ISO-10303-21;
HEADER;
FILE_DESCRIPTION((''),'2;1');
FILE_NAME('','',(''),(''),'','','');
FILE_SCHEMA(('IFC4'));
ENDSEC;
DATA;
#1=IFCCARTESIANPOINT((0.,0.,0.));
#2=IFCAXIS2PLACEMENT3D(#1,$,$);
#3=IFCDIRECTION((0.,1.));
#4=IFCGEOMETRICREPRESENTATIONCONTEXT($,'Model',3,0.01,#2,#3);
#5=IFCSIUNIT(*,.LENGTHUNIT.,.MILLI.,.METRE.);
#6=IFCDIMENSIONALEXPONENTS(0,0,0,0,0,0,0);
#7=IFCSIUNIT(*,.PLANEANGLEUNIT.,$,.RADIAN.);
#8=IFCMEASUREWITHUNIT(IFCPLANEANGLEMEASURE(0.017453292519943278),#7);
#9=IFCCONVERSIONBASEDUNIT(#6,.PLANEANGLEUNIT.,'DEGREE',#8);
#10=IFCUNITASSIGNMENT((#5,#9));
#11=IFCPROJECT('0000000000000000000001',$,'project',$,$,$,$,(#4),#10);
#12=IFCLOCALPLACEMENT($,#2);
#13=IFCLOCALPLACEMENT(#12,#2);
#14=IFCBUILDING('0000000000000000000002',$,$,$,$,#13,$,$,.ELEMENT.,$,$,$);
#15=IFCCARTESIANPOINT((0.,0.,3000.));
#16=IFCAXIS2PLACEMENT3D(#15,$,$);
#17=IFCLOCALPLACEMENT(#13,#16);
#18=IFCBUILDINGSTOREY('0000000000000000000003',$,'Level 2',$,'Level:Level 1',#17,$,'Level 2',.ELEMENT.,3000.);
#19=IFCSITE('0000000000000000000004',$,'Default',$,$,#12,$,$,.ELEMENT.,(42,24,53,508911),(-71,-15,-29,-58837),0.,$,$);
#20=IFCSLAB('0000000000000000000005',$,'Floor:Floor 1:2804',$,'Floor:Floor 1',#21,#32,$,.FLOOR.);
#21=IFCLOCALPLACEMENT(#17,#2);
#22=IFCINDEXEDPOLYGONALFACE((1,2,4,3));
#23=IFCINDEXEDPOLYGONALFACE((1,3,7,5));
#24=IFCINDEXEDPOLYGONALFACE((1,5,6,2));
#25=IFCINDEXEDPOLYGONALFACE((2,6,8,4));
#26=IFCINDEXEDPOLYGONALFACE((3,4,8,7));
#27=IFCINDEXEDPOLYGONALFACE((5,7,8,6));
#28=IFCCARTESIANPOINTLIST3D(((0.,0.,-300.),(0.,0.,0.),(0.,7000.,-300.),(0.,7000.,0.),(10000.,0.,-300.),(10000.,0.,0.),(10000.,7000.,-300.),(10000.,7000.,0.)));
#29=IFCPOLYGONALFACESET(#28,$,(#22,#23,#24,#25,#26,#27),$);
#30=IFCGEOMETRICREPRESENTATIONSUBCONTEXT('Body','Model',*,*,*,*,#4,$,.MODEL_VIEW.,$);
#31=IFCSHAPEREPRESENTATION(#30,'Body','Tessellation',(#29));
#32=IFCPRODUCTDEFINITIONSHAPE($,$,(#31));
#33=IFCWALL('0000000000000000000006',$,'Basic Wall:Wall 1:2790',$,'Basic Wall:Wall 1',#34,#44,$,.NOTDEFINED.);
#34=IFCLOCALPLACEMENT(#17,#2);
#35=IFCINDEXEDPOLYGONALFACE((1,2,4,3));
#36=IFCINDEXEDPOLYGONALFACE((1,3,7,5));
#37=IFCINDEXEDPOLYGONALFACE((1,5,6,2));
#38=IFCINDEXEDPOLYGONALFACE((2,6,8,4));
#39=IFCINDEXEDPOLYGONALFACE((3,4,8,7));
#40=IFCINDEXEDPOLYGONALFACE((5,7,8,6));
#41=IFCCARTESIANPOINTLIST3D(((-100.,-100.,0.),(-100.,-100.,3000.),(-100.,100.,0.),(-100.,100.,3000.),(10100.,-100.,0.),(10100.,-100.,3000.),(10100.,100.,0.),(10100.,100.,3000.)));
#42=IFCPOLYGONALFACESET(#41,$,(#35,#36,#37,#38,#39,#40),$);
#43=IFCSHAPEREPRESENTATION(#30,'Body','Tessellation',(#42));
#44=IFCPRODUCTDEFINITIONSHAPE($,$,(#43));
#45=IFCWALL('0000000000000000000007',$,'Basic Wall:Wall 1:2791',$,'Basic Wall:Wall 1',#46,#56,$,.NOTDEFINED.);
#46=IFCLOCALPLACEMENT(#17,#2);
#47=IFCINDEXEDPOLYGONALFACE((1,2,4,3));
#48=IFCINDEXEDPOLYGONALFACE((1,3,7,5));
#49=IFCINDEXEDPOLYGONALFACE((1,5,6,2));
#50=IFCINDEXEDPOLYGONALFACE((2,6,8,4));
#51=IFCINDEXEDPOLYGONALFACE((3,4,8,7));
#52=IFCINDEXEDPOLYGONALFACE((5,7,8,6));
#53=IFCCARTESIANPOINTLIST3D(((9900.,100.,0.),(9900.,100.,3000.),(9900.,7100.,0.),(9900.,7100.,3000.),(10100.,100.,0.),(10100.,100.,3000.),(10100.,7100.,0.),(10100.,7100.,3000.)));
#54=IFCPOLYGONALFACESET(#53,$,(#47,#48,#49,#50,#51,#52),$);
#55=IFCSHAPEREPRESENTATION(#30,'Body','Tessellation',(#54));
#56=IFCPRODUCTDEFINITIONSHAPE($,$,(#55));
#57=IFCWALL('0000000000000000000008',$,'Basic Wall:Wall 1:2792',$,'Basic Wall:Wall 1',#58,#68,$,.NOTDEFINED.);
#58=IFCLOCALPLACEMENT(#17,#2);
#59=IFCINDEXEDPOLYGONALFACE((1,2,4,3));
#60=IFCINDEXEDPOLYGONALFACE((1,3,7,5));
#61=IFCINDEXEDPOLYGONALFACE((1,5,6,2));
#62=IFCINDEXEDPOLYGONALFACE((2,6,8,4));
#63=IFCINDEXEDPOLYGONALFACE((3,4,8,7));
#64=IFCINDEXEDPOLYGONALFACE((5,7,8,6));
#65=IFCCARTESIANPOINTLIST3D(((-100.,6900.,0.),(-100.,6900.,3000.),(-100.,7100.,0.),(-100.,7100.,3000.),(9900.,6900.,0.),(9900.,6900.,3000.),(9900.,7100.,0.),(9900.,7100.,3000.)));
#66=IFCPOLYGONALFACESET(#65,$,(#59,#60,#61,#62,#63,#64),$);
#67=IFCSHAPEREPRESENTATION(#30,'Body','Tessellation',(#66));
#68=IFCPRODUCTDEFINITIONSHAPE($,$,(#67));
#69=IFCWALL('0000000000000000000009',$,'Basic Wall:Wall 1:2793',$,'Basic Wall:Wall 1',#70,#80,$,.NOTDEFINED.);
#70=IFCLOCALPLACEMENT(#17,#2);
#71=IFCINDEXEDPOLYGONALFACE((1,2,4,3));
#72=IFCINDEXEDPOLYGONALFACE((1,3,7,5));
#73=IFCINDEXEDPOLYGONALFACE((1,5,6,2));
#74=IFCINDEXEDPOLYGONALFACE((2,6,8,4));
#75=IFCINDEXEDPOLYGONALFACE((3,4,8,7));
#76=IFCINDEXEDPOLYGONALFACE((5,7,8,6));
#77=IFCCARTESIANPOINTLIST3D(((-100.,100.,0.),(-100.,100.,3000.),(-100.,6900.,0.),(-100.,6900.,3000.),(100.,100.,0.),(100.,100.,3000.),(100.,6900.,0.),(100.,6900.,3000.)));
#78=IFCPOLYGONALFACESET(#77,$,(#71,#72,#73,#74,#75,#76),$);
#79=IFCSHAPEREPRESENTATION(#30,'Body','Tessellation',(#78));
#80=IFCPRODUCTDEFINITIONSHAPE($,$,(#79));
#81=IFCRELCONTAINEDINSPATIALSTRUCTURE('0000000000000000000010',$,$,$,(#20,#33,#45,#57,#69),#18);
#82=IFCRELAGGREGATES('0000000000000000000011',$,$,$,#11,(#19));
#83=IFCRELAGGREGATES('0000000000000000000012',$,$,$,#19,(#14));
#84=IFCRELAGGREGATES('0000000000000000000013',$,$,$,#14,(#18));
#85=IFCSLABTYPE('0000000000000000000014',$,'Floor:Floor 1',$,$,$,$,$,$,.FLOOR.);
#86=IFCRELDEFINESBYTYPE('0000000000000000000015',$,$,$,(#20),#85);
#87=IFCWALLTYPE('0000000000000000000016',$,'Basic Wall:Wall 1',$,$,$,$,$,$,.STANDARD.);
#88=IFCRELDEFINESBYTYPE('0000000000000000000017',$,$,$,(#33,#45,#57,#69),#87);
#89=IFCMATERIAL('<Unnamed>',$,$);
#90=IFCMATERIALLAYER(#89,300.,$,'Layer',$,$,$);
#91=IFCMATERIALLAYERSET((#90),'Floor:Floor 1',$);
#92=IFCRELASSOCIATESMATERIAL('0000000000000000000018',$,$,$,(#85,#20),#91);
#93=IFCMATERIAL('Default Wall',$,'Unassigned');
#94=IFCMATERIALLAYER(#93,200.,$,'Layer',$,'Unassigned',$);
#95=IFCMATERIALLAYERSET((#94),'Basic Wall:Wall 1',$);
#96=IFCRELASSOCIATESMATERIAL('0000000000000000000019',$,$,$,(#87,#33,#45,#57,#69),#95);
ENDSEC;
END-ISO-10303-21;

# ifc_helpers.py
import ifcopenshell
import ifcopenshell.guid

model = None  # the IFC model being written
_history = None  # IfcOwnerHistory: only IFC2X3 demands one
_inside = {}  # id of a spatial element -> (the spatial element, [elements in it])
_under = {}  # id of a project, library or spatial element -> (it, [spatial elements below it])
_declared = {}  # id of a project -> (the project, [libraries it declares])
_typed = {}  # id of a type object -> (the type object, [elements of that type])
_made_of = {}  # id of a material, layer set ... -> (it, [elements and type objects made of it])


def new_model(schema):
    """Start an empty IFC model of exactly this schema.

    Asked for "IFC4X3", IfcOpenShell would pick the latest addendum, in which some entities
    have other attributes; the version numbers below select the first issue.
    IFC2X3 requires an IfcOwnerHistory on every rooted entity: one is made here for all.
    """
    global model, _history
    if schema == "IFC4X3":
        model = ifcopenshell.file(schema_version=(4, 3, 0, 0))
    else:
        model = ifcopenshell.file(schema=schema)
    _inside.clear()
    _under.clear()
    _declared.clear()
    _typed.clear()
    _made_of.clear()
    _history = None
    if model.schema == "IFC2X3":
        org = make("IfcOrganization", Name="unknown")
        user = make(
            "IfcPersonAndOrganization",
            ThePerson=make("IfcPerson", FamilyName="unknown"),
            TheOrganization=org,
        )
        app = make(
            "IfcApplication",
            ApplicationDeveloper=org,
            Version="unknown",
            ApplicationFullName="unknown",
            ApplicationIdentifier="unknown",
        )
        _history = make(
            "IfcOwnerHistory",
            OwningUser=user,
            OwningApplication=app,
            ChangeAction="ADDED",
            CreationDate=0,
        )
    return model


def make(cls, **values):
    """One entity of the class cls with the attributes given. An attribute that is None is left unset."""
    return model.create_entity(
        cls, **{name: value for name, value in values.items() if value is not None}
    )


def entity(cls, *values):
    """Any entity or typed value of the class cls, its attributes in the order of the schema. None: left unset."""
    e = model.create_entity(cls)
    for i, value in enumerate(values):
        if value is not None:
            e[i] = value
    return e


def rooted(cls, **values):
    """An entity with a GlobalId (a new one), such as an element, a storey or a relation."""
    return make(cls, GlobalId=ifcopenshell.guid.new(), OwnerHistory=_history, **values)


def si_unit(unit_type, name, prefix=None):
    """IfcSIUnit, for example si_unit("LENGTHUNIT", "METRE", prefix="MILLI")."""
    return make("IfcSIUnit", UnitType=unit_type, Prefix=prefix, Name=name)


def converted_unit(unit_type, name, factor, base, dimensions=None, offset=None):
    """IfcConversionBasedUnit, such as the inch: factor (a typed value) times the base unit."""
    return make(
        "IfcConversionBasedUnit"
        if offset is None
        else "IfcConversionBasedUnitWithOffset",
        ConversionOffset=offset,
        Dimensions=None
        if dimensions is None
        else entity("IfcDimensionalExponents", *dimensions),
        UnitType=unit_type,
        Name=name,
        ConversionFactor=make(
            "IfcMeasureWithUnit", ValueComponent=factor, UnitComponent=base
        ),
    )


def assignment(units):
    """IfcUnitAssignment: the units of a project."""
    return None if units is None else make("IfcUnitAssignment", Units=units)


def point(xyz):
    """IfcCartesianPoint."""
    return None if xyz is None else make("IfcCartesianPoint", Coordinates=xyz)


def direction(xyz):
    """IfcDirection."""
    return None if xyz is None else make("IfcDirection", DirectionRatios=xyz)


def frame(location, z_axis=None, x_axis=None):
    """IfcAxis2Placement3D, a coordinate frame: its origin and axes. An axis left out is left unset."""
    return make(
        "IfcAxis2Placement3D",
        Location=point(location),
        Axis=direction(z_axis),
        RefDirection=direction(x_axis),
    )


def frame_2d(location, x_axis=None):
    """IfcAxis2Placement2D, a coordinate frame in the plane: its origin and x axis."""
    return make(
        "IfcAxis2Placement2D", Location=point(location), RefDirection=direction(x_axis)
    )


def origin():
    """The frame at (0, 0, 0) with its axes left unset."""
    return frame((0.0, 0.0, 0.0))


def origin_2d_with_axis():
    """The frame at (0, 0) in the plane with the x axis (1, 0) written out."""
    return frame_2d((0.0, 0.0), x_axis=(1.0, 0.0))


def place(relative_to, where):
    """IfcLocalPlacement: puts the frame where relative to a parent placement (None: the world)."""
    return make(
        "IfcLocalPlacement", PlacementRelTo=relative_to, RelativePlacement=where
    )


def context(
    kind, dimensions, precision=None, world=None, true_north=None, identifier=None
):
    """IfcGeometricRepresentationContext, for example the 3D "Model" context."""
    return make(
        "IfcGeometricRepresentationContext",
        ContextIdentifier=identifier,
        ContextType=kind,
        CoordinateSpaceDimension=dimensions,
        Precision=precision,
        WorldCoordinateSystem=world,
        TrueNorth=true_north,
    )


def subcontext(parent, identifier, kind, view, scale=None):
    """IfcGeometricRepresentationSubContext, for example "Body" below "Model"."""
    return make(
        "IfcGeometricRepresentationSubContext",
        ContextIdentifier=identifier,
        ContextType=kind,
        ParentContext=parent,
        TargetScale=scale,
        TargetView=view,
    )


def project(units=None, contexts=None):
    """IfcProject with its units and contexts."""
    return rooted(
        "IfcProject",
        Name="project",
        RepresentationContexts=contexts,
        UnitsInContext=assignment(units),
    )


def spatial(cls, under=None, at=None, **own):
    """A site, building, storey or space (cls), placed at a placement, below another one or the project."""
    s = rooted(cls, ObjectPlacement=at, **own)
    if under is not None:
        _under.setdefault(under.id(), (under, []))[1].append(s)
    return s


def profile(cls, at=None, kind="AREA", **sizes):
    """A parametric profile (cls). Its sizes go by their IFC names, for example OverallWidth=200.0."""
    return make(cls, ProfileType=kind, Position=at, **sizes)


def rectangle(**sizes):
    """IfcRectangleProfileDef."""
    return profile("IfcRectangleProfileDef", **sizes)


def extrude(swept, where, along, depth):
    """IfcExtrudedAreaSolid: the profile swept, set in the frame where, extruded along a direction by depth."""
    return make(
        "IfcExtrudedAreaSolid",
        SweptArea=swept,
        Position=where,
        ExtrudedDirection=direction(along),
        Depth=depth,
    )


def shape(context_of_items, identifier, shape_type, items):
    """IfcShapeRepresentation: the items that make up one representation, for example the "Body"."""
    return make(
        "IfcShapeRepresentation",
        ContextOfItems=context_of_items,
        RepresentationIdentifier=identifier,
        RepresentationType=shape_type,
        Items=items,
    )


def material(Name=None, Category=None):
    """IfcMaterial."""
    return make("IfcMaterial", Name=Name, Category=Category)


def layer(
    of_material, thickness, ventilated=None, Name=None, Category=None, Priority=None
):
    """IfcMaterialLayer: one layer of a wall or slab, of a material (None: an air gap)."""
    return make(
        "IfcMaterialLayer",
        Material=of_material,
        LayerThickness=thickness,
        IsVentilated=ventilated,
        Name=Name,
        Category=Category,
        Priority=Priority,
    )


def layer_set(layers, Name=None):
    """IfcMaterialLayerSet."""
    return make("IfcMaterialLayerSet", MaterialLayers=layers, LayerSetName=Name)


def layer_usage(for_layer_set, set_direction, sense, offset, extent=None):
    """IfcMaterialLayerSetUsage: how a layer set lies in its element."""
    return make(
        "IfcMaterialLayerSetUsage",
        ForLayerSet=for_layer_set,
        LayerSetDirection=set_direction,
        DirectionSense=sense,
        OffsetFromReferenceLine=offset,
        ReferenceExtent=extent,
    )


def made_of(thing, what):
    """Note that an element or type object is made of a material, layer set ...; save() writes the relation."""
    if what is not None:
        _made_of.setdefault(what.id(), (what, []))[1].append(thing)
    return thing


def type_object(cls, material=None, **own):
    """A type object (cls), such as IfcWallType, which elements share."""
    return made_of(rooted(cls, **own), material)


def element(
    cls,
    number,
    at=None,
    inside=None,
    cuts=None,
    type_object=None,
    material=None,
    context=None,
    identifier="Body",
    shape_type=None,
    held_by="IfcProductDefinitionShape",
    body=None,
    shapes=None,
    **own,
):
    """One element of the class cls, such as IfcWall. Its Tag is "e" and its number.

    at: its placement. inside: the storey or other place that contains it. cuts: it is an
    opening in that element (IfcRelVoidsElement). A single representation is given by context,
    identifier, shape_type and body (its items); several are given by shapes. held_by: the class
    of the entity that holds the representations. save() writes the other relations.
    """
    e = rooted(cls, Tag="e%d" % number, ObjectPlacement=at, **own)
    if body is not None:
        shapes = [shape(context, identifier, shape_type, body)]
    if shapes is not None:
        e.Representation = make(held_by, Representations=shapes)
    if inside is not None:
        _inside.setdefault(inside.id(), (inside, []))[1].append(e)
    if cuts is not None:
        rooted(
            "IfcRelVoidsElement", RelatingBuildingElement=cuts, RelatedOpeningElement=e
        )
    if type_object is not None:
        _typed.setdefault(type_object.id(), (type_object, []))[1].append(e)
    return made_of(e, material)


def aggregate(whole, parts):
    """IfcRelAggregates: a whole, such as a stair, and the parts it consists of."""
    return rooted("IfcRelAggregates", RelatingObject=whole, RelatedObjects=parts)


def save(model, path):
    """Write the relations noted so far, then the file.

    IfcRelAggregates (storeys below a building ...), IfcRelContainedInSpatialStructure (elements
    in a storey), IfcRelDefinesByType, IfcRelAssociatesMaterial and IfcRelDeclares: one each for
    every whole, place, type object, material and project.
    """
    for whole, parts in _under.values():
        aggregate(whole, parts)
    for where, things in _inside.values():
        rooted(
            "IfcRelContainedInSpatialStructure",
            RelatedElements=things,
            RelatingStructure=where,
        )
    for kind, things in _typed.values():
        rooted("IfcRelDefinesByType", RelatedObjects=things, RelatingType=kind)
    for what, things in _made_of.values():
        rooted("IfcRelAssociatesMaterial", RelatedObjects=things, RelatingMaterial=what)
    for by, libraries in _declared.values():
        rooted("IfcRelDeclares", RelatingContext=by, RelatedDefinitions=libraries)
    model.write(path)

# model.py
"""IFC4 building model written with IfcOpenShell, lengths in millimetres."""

from ifc_helpers import new_model, entity, si_unit, converted_unit, direction, frame, frame_2d, origin, origin_2d_with_axis, place, context, subcontext, project, spatial, rectangle, extrude, material, layer, layer_set, layer_usage, type_object, element, save


model = new_model("IFC4")

# Units and contexts
model_context = context("Model", 3, precision=0.01, world=origin(), true_north=direction((0.0, 1.0)))
body_context = subcontext(model_context, "Body", "Model", "MODEL_VIEW")
ifc_project = project(units=[si_unit("LENGTHUNIT", "METRE", prefix="MILLI"), converted_unit("PLANEANGLEUNIT", "DEGREE", entity("IfcPlaneAngleMeasure", 0.017453292519943278), si_unit("PLANEANGLEUNIT", "RADIAN"), dimensions=[0, 0, 0, 0, 0, 0, 0])], contexts=[model_context])

# Site, building, storey
site_placement = place(None, origin())
site = spatial("IfcSite", under=ifc_project, at=site_placement, Name="Default", CompositionType="ELEMENT", RefLatitude=(42, 24, 53, 508911), RefLongitude=(-71, -15, -29, -58837), RefElevation=0.0)
building_placement = place(site_placement, origin())
building = spatial("IfcBuilding", under=site, at=building_placement, CompositionType="ELEMENT")
storey_placement = place(building_placement, frame((0.0, 0.0, 3000.0)))
storey = spatial("IfcBuildingStorey", under=building, at=storey_placement, Name="Level 2", ObjectType="Level:Level 1", LongName="Level 2", CompositionType="ELEMENT", Elevation=3000.0)

# Slab
ifc_material_1 = material(Name="<Unnamed>")
ifc_layer_1 = layer(ifc_material_1, 300.0, Name="Layer")
ifc_layer_set_1 = layer_set([ifc_layer_1], Name="Floor:Floor 1")
ifc_layer_usage_1 = layer_usage(ifc_layer_set_1, "AXIS3", "POSITIVE", 0.0)
slab_type = type_object("IfcSlabType", Name="Floor:Floor 1", PredefinedType="FLOOR", material=ifc_layer_set_1)
slab_placement = place(storey_placement, origin())
element("IfcSlab", 1, at=slab_placement, inside=storey, type_object=slab_type, material=ifc_layer_usage_1, Name="Floor:Floor 1:2804", ObjectType="Floor:Floor 1", PredefinedType="FLOOR", context=body_context, shape_type="SweptSolid", body=[
    extrude(rectangle(XDim=7000.0, YDim=10000.0, at=origin_2d_with_axis()), frame((5000.0, 3500.0, 0.0), z_axis=(0.0, 0.0, -1.0), x_axis=(0.0, 1.0, 0.0)), (0.0, 0.0, 1.0), 300.0),
])

# Walls
ifc_material_2 = material(Name="Default Wall", Category="Unassigned")
ifc_layer_2 = layer(ifc_material_2, 200.0, Name="Layer", Category="Unassigned")
ifc_layer_set_2 = layer_set([ifc_layer_2], Name="Basic Wall:Wall 1")
ifc_layer_usage_2 = layer_usage(ifc_layer_set_2, "AXIS2", "NEGATIVE", 100.0)
wall_type = type_object("IfcWallType", Name="Basic Wall:Wall 1", PredefinedType="STANDARD", material=ifc_layer_set_2)
wall_1_placement = place(storey_placement, frame((-100.0, 0.0, 0.0)))
element("IfcWall", 2, at=wall_1_placement, inside=storey, type_object=wall_type, material=ifc_layer_usage_2, Name="Basic Wall:Wall 1:2790", ObjectType="Basic Wall:Wall 1", PredefinedType="NOTDEFINED", context=body_context, shape_type="SweptSolid", body=[
    extrude(rectangle(XDim=10200.0, YDim=200.0, at=frame_2d((5100.0, 0.0), x_axis=(-1.0, 0.0))), origin(), (0.0, 0.0, 1.0), 3000.0),
])
ifc_layer_usage_3 = layer_usage(ifc_layer_set_2, "AXIS2", "NEGATIVE", 100.0)
wall_2_placement = place(storey_placement, frame((10000.0, 100.0, 0.0), z_axis=(0.0, 0.0, 1.0), x_axis=(0.0, 1.0, 0.0)))
element("IfcWall", 3, at=wall_2_placement, inside=storey, type_object=wall_type, material=ifc_layer_usage_3, Name="Basic Wall:Wall 1:2791", ObjectType="Basic Wall:Wall 1", PredefinedType="NOTDEFINED", context=body_context, shape_type="SweptSolid", body=[
    extrude(rectangle(XDim=7000.0, YDim=200.0, at=frame_2d((3500.0, 0.0), x_axis=(-1.0, 0.0))), origin(), (0.0, 0.0, 1.0), 3000.0),
])
ifc_layer_usage_4 = layer_usage(ifc_layer_set_2, "AXIS2", "NEGATIVE", 100.0)
wall_3_placement = place(storey_placement, frame((9900.0, 7000.0, 0.0), z_axis=(0.0, 0.0, 1.0), x_axis=(-1.0, 0.0, 0.0)))
element("IfcWall", 4, at=wall_3_placement, inside=storey, type_object=wall_type, material=ifc_layer_usage_4, Name="Basic Wall:Wall 1:2792", ObjectType="Basic Wall:Wall 1", PredefinedType="NOTDEFINED", context=body_context, shape_type="SweptSolid", body=[
    extrude(rectangle(XDim=10000.0, YDim=200.0, at=frame_2d((5000.0, 0.0), x_axis=(-1.0, 0.0))), origin(), (0.0, 0.0, 1.0), 3000.0),
])
ifc_layer_usage_5 = layer_usage(ifc_layer_set_2, "AXIS2", "NEGATIVE", 100.0)
wall_4_placement = place(storey_placement, frame((0.0, 6900.0, 0.0), z_axis=(0.0, 0.0, 1.0), x_axis=(0.0, -1.0, 0.0)))
element("IfcWall", 5, at=wall_4_placement, inside=storey, type_object=wall_type, material=ifc_layer_usage_5, Name="Basic Wall:Wall 1:2793", ObjectType="Basic Wall:Wall 1", PredefinedType="NOTDEFINED", context=body_context, shape_type="SweptSolid", body=[
    extrude(rectangle(XDim=6800.0, YDim=200.0, at=frame_2d((3400.0, 0.0), x_axis=(-1.0, 0.0))), origin(), (0.0, 0.0, 1.0), 3000.0),
])

save(model, "model.ifc")
